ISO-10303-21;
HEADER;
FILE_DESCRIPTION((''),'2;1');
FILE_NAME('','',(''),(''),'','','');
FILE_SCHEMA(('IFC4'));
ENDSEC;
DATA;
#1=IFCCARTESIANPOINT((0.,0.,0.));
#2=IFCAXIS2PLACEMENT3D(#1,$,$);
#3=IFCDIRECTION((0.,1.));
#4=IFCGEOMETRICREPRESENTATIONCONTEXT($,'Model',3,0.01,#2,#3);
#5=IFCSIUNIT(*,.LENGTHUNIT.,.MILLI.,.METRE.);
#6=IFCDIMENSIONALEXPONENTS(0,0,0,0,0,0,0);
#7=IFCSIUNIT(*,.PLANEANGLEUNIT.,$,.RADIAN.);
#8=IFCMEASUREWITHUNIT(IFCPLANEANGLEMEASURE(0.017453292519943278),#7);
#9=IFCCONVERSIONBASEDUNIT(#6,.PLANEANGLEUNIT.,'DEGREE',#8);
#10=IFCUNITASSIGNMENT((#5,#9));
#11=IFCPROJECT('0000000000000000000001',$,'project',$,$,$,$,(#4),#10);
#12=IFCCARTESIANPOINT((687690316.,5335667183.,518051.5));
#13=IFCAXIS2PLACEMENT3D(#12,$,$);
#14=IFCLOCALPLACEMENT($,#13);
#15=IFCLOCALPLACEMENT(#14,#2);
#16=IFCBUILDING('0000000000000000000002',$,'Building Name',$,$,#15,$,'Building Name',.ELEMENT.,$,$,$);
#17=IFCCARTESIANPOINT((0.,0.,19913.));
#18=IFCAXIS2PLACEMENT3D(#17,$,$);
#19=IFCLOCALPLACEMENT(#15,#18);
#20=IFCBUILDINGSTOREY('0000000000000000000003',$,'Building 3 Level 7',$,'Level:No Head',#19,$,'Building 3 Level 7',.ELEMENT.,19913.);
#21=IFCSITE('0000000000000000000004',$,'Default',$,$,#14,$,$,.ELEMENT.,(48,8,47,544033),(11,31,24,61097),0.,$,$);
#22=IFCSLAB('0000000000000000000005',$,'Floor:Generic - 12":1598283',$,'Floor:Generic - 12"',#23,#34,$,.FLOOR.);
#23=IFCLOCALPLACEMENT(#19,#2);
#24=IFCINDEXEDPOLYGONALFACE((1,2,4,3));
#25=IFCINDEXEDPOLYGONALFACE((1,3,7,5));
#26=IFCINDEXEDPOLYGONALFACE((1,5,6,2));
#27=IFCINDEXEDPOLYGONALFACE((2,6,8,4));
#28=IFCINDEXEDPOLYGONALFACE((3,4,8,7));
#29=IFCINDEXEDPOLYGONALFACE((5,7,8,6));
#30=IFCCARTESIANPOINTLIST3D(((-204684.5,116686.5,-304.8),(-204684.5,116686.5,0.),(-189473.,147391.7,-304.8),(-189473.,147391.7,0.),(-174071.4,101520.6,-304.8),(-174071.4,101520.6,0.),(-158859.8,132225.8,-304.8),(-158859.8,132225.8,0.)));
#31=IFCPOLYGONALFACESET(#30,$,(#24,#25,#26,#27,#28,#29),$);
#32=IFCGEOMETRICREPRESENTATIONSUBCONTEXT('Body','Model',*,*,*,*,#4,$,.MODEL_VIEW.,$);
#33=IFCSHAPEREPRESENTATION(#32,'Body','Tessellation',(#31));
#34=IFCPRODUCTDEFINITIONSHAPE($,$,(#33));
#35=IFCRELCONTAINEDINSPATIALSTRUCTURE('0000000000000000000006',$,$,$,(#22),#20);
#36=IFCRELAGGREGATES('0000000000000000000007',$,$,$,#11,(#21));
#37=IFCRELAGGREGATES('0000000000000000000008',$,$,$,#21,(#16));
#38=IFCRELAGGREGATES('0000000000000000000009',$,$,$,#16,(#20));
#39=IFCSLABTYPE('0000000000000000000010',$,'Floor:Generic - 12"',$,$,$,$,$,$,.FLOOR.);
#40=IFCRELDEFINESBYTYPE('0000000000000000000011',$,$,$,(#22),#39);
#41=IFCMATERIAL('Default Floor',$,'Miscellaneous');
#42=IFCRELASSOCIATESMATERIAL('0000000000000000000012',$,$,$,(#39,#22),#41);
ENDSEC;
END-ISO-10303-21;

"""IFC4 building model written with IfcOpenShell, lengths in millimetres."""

from ifc_helpers import new_model, entity, si_unit, converted_unit, direction, frame, origin, place, context, subcontext, project, spatial, indexed_curve, outline, extrude, material, type_object, element, save


model = new_model("IFC4")

# Units and contexts
model_context = context("Model", 3, precision=0.01, world=origin(), true_north=direction((0.0, 1.0)))
body_context = subcontext(model_context, "Body", "Model", "MODEL_VIEW")
ifc_project = project(units=[si_unit("LENGTHUNIT", "METRE", prefix="MILLI"), converted_unit("PLANEANGLEUNIT", "DEGREE", entity("IfcPlaneAngleMeasure", 0.017453292519943278), si_unit("PLANEANGLEUNIT", "RADIAN"), dimensions=[0, 0, 0, 0, 0, 0, 0])], contexts=[model_context])

# Site, building, storey
site_placement = place(None, frame((687690316.0, 5335667183.0, 518051.5)))
site = spatial("IfcSite", under=ifc_project, at=site_placement, Name="Default", CompositionType="ELEMENT", RefLatitude=(48, 8, 47, 544033), RefLongitude=(11, 31, 24, 61097), RefElevation=0.0)
building_placement = place(site_placement, origin())
building = spatial("IfcBuilding", under=site, at=building_placement, Name="Building Name", LongName="Building Name", CompositionType="ELEMENT")
storey_placement = place(building_placement, frame((0.0, 0.0, 19913.0)))
storey = spatial("IfcBuildingStorey", under=building, at=storey_placement, Name="Building 3 Level 7", ObjectType="Level:No Head", LongName="Building 3 Level 7", CompositionType="ELEMENT", Elevation=19913.0)

# Slab
ifc_material = material(Name="Default Floor", Category="Miscellaneous")
slab_type = type_object("IfcSlabType", Name="Floor:Generic - 12\"", PredefinedType="FLOOR", material=ifc_material)
slab_placement = place(storey_placement, origin())
element("IfcSlab", 1, at=slab_placement, inside=storey, type_object=slab_type, material=ifc_material, Name="Floor:Generic - 12\":1598283", ObjectType="Floor:Generic - 12\"", PredefinedType="FLOOR", context=body_context, shape_type="SweptSolid", body=[
    extrude(outline(indexed_curve([(-17081.9, -17133.3), (17081.9, -17133.3), (17081.9, 17133.3), (-17081.9, 17133.3), (-17081.9, -17133.3)], self_intersect=False)), frame((-181772.2, 124456.1, 0.0), z_axis=(0.0, 0.0, -1.0), x_axis=(0.896068, -0.443917, 0.0)), (0.0, 0.0, 1.0), 304.8),
])

save(model, "model.ifc")
